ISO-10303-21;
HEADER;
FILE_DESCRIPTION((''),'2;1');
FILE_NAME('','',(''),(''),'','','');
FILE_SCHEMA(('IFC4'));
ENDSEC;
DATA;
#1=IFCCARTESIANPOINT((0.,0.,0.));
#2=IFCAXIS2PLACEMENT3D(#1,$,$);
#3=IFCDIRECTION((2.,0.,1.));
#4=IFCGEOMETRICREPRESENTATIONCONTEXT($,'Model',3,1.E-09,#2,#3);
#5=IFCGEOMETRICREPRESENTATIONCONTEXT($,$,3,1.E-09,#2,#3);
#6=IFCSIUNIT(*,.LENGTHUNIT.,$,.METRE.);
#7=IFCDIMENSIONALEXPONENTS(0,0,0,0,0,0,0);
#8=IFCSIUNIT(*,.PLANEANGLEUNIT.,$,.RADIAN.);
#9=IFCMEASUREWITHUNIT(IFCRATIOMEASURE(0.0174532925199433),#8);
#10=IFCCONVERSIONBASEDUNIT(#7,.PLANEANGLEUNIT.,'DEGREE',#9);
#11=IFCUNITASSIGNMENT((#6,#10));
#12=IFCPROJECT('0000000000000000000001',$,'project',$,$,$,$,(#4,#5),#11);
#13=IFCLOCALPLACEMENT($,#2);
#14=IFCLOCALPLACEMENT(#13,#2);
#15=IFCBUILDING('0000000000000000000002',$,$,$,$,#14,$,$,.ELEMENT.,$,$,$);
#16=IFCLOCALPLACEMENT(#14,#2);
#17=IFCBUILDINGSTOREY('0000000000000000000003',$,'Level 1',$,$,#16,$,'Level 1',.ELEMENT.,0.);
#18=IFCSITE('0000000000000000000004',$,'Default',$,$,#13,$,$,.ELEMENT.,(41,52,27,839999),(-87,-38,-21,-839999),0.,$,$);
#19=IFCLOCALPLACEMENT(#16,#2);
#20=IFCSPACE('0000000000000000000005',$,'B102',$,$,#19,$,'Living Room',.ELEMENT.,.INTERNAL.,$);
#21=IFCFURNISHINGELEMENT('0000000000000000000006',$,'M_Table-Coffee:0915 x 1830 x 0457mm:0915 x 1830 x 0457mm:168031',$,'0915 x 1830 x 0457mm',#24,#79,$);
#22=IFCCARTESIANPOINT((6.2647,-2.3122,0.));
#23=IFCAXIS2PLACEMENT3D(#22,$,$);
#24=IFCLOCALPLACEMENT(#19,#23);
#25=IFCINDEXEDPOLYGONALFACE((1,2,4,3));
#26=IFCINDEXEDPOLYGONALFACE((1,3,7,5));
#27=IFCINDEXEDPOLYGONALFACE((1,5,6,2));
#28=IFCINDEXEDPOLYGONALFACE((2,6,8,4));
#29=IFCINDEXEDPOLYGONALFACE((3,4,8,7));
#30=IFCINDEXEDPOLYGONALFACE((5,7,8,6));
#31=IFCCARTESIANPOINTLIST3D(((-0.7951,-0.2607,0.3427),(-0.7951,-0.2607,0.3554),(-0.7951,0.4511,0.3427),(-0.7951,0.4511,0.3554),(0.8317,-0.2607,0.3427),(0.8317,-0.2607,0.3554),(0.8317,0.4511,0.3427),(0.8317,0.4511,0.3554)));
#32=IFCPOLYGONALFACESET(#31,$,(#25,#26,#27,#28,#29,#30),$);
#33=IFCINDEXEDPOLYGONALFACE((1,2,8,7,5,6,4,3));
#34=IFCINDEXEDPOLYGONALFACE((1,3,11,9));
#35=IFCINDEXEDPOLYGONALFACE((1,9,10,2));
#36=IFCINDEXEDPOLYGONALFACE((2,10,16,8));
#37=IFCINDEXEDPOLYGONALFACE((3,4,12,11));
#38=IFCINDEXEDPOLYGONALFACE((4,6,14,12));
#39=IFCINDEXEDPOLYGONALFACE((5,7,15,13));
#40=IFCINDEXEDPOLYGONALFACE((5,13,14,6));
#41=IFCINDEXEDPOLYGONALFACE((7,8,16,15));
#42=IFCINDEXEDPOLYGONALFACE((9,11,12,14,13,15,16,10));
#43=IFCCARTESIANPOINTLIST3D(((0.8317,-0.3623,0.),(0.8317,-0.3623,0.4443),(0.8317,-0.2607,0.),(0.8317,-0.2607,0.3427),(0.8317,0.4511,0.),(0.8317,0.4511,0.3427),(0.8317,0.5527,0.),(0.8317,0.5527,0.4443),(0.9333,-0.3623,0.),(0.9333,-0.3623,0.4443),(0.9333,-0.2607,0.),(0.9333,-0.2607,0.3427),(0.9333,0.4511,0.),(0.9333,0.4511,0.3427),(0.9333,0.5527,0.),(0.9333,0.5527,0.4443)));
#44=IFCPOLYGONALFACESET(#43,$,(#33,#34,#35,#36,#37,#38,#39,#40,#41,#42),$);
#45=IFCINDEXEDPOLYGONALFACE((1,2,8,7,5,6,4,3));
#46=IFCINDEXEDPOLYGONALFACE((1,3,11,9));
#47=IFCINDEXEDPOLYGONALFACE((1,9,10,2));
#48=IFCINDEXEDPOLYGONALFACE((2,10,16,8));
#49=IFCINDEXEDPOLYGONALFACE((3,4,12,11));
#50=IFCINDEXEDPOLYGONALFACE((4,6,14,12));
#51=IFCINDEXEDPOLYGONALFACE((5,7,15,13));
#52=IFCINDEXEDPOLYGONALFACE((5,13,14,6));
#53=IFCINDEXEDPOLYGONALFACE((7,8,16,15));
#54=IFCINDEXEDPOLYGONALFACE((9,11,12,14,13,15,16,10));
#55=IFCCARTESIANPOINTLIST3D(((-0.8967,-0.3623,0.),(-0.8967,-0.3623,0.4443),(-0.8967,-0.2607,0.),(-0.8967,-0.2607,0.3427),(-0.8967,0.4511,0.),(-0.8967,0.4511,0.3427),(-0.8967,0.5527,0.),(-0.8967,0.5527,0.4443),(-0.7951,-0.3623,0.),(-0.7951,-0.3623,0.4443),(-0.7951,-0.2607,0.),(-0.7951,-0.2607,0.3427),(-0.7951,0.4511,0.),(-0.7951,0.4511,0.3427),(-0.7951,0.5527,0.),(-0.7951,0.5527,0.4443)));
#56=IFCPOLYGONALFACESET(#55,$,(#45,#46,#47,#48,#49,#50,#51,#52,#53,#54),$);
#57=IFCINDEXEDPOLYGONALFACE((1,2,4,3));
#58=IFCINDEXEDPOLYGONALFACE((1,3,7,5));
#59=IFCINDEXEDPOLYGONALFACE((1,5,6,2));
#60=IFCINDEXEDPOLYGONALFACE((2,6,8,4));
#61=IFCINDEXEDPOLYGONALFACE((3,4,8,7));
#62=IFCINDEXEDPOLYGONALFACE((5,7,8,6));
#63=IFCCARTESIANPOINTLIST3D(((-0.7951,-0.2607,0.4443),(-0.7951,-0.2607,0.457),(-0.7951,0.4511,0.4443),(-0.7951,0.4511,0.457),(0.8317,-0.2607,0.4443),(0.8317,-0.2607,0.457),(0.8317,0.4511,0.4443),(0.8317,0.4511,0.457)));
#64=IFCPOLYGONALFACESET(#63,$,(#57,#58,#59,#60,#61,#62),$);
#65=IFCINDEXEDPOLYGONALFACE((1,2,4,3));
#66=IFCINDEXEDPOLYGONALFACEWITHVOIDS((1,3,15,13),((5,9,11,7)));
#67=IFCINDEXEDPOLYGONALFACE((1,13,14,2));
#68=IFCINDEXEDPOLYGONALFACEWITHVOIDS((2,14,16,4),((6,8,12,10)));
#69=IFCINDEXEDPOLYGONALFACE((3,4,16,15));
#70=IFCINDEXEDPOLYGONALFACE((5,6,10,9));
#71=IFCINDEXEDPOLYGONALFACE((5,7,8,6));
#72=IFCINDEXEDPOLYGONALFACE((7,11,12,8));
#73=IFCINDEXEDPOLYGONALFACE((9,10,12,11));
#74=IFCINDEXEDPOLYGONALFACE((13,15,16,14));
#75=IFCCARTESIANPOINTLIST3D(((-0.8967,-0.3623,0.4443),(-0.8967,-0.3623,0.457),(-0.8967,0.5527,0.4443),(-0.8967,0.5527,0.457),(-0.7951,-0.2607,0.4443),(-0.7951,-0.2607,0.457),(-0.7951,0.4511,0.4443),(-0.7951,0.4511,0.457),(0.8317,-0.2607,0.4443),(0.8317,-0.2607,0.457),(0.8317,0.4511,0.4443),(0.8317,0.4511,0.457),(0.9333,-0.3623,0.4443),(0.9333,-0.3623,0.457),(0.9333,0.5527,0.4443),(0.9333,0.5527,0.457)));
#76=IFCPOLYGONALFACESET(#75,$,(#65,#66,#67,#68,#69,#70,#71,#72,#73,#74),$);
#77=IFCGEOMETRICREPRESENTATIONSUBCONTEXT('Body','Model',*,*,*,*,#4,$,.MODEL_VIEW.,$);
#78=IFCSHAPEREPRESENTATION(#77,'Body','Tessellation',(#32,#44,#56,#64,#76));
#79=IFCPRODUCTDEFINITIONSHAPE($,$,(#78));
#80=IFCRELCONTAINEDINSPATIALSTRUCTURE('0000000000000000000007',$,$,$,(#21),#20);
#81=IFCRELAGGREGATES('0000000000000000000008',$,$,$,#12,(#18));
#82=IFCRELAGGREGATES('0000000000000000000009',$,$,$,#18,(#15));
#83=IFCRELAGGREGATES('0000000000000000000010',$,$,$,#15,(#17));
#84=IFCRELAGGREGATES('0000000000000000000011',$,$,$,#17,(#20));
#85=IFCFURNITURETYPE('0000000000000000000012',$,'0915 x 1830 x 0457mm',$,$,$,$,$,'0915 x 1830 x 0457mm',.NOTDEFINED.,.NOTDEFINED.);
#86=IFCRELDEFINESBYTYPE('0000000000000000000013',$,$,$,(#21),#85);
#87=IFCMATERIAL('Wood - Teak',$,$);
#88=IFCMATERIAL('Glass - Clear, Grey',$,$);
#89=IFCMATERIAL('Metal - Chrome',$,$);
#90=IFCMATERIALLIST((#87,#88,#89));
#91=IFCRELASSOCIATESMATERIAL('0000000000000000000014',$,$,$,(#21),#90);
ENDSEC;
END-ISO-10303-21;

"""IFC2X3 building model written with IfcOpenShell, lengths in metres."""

from ifc_helpers import new_model, entity, si_unit, converted_unit, direction, frame, origin, origin_2d_with_axis, place, context, subcontext, project, spatial, polyline, rectangle, outline, extrude, source, transform, mapped, material, material_list, type_object, type_shapes, element, save


model = new_model("IFC2X3")

# Units and contexts
model_context = context("Model", 3, precision=1e-09, world=origin(), true_north=direction((2.0, 0.0, 1.0)))
context_of_model = context(None, 3, precision=1e-09, world=origin(), true_north=direction((2.0, 0.0, 1.0)))
body_context = subcontext(model_context, "Body", "Model", "MODEL_VIEW")
ifc_project = project(units=[si_unit("LENGTHUNIT", "METRE"), converted_unit("PLANEANGLEUNIT", "DEGREE", entity("IfcRatioMeasure", 0.0174532925199433), si_unit("PLANEANGLEUNIT", "RADIAN"), dimensions=[0, 0, 0, 0, 0, 0, 0])], contexts=[model_context, context_of_model])

# Site, building, storey
site_placement = place(None, origin())
site = spatial("IfcSite", under=ifc_project, at=site_placement, Name="Default", CompositionType="ELEMENT", RefLatitude=(41, 52, 27, 839999), RefLongitude=(-87, -38, -21, -839999), RefElevation=0.0)
building_placement = place(site_placement, origin())
building = spatial("IfcBuilding", under=site, at=building_placement, CompositionType="ELEMENT")
storey_placement = place(building_placement, origin())
storey = spatial("IfcBuildingStorey", under=building, at=storey_placement, Name="Level 1", LongName="Level 1", CompositionType="ELEMENT", Elevation=0.0)

# Shared definitions
space_1_placement = place(storey_placement, origin())
space_1 = spatial("IfcSpace", under=storey, at=space_1_placement, Name="B102", LongName="Living Room", CompositionType="ELEMENT", InteriorOrExteriorSpace="INTERNAL")

# Furnishing element
ifc_material_1 = material(Name="Wood - Teak")
ifc_material_2 = material(Name="Glass - Clear, Grey")
ifc_material_3 = material(Name="Metal - Chrome")
ifc_material_list_1 = material_list([ifc_material_1, ifc_material_2, ifc_material_3])
furniture_type_1 = type_object("IfcFurnitureType", Name="0915 x 1830 x 0457mm", ElementType="0915 x 1830 x 0457mm", AssemblyPlace="NOTDEFINED")
shared_shape_1 = source(origin(), body_context, "Body", "SweptSolid", [
    extrude(rectangle(XDim=1.6268, YDim=0.7118, at=origin_2d_with_axis()), frame((0.0183, 0.0952, 0.3427), z_axis=(0.0, 0.0, 1.0), x_axis=(-1.0, 0.0, 0.0)), (0.0, 0.0, 1.0), 0.0127),
    extrude(outline(polyline([(-0.1967, -0.4575), (0.2475, -0.4575), (0.2475, 0.4575), (-0.1967, 0.4575), (-0.1967, 0.3559), (0.146, 0.3559), (0.146, -0.3559), (-0.1967, -0.3559), (-0.1967, -0.4575)])), frame((0.8317, 0.0952, 0.1967), z_axis=(1.0, 0.0, 0.0), x_axis=(0.0, 0.0, 1.0)), (0.0, 0.0, 1.0), 0.1016),
    extrude(outline(polyline([(-0.4575, -0.2476), (0.4575, -0.2476), (0.4575, 0.1968), (0.3559, 0.1968), (0.3559, -0.1459), (-0.3559, -0.1459), (-0.3559, 0.1968), (-0.4575, 0.1968), (-0.4575, -0.2476)])), frame((-0.8967, 0.0952, 0.1968), z_axis=(1.0, 0.0, 0.0), x_axis=(0.0, -1.0, 0.0)), (0.0, 0.0, 1.0), 0.1016),
    extrude(rectangle(XDim=1.6268, YDim=0.7118, at=origin_2d_with_axis()), frame((0.0183, 0.0952, 0.4443), z_axis=(0.0, 0.0, 1.0), x_axis=(-1.0, 0.0, 0.0)), (0.0, 0.0, 1.0), 0.0127),
    extrude(outline(polyline([(-0.915, -0.4575), (0.915, -0.4575), (0.915, 0.4575), (-0.915, 0.4575), (-0.915, -0.4575)]), holes=[polyline([(-0.8134, -0.3559), (-0.8134, 0.3559), (0.8134, 0.3559), (0.8134, -0.3559), (-0.8134, -0.3559)])]), frame((0.0183, 0.0952, 0.4443), z_axis=(0.0, 0.0, 1.0), x_axis=(-1.0, 0.0, 0.0)), (0.0, 0.0, 1.0), 0.0127),
])
type_shapes(furniture_type_1, [shared_shape_1])
furnishing_1_placement = place(space_1_placement, frame((6.2647, -2.3122, 0.0)))
element("IfcFurnishingElement", 1, at=furnishing_1_placement, inside=space_1, type_object=furniture_type_1, material=ifc_material_list_1, Name="M_Table-Coffee:0915 x 1830 x 0457mm:0915 x 1830 x 0457mm:168031", ObjectType="0915 x 1830 x 0457mm", context=body_context, shape_type="MappedRepresentation", body=[
    mapped(shared_shape_1, transform((0.0, 0.0, 0.0), scale=1.0)),
])

save(model, "model.ifc")
